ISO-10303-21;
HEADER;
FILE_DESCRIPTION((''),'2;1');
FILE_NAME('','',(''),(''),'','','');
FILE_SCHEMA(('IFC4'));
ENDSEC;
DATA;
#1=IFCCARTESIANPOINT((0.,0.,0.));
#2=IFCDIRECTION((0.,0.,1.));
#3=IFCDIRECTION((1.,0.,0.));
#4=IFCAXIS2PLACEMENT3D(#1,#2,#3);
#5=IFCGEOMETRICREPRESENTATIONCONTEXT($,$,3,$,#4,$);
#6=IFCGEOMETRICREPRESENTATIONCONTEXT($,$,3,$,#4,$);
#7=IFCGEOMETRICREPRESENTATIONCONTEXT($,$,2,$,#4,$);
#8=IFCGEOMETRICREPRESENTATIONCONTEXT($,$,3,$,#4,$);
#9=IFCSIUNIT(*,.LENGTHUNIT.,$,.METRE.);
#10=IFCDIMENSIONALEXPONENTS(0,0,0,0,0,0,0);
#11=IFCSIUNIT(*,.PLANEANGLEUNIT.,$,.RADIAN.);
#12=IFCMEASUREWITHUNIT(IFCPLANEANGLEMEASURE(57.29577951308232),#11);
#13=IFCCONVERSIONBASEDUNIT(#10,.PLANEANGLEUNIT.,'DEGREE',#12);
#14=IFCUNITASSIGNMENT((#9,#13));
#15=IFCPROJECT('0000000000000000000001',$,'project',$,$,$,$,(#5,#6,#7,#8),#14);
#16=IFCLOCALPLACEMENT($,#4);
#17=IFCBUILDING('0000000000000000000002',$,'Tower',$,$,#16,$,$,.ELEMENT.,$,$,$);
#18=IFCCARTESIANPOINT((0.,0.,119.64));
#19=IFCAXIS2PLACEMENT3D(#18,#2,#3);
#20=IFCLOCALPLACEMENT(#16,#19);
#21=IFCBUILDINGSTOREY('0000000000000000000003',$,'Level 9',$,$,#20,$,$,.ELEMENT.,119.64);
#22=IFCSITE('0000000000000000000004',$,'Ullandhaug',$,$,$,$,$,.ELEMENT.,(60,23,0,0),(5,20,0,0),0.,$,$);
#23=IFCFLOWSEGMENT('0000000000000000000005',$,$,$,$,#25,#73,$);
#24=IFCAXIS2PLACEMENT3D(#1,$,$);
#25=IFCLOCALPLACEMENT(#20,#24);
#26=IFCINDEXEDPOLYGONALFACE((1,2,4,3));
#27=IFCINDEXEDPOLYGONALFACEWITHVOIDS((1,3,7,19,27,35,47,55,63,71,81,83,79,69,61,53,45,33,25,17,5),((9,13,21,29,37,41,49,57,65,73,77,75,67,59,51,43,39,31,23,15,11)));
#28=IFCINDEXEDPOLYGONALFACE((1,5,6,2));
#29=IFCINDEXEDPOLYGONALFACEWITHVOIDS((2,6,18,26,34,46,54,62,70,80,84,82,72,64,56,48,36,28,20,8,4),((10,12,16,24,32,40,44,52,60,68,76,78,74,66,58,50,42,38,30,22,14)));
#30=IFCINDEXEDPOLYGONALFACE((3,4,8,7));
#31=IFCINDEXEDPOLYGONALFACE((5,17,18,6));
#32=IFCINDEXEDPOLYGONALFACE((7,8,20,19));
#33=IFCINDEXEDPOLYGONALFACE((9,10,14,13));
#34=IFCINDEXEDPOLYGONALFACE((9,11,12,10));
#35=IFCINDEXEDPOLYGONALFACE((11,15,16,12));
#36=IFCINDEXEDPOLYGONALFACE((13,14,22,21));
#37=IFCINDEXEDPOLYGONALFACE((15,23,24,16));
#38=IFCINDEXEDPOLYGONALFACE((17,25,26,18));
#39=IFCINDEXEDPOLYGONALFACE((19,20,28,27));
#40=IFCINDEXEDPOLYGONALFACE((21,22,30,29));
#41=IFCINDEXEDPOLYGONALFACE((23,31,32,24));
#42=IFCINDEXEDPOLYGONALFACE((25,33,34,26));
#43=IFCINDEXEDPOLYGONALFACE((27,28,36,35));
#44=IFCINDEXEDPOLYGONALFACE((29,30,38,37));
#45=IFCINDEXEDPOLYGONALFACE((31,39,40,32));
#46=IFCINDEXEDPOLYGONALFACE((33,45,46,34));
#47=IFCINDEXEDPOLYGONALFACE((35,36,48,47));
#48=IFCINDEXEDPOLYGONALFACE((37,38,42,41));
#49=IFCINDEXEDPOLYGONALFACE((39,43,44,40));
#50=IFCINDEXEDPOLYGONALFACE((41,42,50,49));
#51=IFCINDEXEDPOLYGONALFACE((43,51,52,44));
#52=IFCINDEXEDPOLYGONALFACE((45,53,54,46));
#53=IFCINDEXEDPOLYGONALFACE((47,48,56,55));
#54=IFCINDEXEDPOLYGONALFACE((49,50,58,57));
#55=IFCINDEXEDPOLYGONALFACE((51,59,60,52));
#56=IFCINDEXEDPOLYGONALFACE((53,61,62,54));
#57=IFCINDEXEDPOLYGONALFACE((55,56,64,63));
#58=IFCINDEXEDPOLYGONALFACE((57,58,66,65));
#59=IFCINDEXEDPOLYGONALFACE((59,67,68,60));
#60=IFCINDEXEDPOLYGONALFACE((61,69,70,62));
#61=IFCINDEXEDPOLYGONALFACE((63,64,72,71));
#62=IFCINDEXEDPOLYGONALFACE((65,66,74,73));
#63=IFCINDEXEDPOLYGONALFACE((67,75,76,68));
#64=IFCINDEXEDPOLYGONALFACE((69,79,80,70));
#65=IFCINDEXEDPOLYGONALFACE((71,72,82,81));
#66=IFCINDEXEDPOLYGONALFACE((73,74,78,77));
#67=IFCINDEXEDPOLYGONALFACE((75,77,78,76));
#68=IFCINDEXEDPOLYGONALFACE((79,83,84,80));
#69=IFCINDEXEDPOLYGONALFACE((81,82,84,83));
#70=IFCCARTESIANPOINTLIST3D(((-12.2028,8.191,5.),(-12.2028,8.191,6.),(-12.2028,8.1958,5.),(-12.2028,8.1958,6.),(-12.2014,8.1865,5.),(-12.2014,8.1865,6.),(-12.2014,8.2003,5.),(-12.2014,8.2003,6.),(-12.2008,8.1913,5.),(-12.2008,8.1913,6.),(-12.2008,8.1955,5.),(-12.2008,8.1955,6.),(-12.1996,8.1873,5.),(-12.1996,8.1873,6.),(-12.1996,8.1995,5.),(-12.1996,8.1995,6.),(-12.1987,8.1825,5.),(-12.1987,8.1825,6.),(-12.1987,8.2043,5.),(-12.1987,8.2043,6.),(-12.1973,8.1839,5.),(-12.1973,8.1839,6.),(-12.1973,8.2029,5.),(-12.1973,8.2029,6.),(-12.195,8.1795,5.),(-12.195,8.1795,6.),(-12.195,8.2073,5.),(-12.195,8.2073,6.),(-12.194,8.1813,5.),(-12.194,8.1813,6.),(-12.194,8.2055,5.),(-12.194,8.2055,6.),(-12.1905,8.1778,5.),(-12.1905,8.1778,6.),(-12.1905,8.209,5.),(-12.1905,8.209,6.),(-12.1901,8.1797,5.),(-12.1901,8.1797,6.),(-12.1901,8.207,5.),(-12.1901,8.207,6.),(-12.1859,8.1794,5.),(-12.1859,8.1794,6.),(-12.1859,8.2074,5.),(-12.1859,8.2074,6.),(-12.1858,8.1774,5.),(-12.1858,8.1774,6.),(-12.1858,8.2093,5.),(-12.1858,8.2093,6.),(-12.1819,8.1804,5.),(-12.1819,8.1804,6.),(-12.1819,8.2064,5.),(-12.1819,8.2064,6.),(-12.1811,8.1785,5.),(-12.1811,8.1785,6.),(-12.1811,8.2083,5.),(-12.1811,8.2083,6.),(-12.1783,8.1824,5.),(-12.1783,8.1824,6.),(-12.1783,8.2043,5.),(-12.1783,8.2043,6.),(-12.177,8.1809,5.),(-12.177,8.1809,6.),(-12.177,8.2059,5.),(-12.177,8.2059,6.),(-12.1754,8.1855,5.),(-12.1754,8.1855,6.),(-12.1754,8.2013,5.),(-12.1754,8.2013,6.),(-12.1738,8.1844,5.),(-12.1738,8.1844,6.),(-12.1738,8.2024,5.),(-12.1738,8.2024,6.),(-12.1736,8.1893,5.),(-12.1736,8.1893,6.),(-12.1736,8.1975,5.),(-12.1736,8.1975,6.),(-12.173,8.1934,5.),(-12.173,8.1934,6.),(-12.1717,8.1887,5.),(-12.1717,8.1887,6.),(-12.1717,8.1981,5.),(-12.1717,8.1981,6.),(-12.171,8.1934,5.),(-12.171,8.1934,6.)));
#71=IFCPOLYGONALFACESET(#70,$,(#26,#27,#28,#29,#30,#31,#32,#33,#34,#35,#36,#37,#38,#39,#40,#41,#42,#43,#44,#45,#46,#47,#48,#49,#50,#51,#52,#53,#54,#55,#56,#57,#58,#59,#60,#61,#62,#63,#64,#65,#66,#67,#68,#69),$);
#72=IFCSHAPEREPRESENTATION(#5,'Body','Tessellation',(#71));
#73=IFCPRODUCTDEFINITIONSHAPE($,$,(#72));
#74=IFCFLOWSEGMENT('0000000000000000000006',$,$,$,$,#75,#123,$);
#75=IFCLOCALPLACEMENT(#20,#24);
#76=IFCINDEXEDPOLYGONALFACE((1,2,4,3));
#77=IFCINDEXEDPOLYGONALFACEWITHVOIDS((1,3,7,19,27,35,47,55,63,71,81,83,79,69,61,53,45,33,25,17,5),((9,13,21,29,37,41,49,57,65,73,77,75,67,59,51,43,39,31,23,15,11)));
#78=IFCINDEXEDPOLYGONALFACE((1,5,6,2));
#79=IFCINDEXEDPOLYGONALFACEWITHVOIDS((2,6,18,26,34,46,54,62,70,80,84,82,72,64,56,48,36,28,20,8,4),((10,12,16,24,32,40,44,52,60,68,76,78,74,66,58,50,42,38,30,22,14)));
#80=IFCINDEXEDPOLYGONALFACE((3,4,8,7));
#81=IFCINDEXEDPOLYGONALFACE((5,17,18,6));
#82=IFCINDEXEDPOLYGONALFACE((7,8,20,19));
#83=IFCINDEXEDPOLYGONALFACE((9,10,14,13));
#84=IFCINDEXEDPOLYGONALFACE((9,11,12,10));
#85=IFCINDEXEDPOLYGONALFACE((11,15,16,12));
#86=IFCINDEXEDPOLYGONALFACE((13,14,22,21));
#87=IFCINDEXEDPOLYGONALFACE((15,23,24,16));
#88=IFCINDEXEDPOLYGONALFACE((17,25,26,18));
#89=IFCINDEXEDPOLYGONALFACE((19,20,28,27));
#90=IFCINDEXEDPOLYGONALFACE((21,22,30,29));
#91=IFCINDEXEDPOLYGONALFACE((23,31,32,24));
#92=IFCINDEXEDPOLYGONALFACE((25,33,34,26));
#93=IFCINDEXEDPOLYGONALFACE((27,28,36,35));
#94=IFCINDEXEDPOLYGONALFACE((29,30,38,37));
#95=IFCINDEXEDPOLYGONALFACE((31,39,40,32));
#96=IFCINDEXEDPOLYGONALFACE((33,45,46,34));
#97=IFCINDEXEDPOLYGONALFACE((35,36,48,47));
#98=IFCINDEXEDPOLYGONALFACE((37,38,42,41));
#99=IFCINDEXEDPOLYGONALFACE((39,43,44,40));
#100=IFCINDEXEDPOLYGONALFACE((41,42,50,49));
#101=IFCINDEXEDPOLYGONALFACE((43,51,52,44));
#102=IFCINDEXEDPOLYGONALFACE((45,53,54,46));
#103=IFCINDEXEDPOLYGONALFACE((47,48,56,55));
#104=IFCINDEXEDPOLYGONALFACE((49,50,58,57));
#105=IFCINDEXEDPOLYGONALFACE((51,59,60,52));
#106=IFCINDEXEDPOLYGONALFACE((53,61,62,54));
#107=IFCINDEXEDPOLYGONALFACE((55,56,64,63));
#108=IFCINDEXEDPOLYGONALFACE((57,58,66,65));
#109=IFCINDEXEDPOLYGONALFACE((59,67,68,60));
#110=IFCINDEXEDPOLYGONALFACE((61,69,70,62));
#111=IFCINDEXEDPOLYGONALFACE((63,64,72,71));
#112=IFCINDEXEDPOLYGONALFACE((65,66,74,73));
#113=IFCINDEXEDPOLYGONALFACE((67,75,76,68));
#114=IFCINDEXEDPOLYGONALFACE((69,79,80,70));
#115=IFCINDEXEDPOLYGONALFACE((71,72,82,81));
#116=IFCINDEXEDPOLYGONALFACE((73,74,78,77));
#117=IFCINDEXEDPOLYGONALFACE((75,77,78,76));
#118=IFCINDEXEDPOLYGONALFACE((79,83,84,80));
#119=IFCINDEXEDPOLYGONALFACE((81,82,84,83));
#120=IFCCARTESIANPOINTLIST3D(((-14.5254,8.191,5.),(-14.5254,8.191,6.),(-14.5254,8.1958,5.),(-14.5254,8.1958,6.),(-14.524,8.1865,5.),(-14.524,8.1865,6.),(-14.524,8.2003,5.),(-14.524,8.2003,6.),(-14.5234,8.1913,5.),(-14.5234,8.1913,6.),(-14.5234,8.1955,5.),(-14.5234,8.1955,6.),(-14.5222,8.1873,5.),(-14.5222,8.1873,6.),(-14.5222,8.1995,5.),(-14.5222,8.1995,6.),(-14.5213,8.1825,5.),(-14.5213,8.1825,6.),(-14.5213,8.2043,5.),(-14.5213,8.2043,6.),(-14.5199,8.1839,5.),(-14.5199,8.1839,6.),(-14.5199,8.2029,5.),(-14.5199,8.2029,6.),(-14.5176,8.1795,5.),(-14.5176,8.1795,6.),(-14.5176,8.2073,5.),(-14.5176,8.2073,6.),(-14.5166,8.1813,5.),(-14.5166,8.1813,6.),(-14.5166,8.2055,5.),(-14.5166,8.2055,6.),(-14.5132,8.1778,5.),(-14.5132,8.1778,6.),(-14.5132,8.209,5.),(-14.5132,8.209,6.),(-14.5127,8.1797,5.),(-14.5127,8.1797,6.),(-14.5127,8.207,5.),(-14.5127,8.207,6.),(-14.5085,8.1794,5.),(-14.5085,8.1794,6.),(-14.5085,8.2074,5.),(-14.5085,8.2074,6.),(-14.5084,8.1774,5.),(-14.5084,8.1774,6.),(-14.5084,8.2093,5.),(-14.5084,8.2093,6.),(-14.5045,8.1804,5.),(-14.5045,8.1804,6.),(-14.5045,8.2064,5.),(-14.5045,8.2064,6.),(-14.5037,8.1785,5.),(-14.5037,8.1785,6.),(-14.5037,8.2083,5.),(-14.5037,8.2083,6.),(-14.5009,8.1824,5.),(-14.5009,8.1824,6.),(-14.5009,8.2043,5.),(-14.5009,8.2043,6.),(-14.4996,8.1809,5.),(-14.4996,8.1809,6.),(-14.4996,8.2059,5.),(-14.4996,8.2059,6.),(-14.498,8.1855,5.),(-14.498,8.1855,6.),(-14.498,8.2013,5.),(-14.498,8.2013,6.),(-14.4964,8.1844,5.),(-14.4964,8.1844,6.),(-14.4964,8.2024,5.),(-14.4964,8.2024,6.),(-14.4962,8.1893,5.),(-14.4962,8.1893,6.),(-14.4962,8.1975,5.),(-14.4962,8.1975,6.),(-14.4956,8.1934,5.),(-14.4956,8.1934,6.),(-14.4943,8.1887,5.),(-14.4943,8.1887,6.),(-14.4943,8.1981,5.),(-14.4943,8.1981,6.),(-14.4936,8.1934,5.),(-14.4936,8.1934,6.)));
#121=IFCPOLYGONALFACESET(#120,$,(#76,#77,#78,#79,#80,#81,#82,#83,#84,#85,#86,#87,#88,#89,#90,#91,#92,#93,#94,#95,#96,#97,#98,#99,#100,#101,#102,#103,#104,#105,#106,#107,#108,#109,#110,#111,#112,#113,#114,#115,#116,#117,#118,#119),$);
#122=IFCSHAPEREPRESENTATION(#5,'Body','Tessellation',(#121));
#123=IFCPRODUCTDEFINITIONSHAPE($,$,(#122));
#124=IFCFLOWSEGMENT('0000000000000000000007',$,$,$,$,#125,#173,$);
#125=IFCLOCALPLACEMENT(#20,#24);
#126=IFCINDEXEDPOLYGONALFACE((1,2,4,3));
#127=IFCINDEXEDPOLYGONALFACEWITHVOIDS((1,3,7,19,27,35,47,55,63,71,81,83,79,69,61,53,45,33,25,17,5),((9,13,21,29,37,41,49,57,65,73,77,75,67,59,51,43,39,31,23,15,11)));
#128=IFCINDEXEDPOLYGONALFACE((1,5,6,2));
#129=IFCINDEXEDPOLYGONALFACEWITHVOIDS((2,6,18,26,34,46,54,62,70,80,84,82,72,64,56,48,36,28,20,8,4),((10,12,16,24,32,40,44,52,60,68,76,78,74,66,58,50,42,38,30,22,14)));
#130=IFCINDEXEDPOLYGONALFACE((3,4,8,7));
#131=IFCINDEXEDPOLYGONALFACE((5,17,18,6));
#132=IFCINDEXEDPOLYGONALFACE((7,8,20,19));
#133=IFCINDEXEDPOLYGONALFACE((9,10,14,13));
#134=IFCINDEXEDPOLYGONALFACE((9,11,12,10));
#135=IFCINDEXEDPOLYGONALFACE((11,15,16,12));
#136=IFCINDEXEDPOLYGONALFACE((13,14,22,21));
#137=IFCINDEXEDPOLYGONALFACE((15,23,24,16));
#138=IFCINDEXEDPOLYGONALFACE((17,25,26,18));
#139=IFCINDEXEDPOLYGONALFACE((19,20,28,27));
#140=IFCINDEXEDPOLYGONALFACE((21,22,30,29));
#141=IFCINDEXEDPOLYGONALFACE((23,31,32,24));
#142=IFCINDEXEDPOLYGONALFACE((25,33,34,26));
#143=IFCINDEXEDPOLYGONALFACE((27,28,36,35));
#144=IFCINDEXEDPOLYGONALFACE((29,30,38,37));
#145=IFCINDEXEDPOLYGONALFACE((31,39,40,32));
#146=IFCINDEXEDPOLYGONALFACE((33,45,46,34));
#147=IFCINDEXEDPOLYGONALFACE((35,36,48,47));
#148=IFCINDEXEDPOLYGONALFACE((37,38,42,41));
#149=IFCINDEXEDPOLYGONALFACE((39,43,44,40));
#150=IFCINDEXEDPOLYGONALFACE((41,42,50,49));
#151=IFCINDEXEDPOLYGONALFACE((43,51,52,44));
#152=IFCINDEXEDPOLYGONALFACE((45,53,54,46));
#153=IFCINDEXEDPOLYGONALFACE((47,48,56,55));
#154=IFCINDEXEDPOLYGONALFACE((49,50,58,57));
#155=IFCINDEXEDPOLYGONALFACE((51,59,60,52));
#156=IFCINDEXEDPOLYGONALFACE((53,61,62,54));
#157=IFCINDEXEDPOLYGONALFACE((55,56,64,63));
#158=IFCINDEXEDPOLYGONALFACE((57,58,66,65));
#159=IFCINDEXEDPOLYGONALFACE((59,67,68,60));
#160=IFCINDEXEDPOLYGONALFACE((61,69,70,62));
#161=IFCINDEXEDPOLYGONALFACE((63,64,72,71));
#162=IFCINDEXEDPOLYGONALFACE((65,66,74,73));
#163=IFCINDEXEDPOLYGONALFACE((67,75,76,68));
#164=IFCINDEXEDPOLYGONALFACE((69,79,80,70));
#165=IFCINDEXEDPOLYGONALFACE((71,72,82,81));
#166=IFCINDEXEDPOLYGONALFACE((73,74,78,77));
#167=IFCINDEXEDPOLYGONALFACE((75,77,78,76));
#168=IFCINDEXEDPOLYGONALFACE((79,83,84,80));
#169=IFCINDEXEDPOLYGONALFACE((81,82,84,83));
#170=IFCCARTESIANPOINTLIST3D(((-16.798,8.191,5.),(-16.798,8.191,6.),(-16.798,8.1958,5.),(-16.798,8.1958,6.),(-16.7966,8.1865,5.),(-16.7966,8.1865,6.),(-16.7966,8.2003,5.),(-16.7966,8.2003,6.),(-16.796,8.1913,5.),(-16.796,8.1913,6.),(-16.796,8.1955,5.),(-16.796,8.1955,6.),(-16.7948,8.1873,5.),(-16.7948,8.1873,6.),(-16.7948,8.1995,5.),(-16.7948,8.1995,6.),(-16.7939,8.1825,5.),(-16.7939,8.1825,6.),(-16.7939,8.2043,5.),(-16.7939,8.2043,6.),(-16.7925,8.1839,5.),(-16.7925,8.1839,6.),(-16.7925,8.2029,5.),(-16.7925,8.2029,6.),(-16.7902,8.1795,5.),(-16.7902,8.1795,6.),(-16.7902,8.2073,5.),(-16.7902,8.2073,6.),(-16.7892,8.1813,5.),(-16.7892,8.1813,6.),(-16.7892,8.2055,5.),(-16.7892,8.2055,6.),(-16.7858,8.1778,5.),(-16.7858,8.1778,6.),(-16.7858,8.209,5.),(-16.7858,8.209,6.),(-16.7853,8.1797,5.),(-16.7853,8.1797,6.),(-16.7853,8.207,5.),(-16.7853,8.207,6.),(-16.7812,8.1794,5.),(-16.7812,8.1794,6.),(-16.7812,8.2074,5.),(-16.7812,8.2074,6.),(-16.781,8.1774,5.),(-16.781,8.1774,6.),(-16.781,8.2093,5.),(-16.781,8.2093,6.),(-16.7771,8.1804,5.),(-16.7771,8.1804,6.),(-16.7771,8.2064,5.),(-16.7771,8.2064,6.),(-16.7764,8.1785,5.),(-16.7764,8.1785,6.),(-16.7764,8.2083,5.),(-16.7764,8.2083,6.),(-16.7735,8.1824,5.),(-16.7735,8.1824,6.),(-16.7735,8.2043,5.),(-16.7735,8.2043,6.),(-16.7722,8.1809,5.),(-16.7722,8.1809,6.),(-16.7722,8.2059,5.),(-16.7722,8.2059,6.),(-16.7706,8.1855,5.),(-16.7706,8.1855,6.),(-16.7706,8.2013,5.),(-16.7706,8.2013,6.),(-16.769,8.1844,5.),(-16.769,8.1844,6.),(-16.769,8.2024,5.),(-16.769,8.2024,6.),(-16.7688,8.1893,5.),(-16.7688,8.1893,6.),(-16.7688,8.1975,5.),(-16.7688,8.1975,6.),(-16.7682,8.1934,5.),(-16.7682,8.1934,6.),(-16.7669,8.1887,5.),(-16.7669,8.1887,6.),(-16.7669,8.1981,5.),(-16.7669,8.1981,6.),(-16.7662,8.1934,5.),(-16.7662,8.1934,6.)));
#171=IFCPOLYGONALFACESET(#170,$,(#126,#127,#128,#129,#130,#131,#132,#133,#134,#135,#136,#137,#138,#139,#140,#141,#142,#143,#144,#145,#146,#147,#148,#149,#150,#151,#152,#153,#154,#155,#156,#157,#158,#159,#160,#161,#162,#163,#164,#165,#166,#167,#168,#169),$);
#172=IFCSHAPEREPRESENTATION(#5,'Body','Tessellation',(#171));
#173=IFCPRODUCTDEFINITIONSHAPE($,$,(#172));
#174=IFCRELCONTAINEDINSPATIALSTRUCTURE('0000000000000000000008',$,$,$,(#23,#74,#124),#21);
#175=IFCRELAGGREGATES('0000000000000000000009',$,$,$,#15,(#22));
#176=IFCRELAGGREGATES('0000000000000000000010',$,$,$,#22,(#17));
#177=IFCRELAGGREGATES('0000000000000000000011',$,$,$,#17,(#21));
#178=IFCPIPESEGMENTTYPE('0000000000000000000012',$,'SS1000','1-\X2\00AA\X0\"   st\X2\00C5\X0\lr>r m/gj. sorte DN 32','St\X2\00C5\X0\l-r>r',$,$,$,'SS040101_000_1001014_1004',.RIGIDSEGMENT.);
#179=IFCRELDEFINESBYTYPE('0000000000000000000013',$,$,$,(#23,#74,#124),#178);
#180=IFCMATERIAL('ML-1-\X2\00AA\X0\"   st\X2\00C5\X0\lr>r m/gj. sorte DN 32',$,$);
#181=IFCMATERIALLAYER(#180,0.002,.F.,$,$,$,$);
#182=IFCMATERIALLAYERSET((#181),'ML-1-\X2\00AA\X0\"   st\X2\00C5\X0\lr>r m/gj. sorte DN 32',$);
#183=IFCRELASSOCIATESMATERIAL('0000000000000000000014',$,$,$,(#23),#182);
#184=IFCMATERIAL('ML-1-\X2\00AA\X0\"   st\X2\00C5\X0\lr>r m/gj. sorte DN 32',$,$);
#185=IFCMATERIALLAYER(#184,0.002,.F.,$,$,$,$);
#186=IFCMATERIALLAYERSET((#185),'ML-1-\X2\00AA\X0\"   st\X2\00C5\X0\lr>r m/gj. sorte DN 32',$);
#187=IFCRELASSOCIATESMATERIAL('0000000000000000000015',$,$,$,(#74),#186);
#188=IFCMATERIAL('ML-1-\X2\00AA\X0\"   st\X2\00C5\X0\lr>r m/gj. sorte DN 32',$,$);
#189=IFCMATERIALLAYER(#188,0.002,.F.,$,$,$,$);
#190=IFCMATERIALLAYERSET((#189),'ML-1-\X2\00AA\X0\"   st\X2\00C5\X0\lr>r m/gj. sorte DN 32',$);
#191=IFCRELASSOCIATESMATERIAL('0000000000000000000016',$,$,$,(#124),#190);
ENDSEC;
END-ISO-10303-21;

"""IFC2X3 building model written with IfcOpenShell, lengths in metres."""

from ifc_helpers import new_model, entity, si_unit, converted_unit, frame, origin_with_axes, origin_2d_with_axis, place, context, project, spatial, hollow_circle, extrude, material, layer, layer_set, layer_usage, type_object, element, save


model = new_model("IFC2X3")

# Units and contexts
context_of_model_1 = context(None, 3, world=origin_with_axes())
context_of_model_2 = context(None, 3, world=origin_with_axes())
context_of_model_3 = context(None, 2, world=origin_with_axes())
context_of_model_4 = context(None, 3, world=origin_with_axes())
ifc_project = project(units=[si_unit("LENGTHUNIT", "METRE"), converted_unit("PLANEANGLEUNIT", "DEGREE", entity("IfcPlaneAngleMeasure", 57.29577951308232), si_unit("PLANEANGLEUNIT", "RADIAN"), dimensions=[0, 0, 0, 0, 0, 0, 0])], contexts=[context_of_model_1, context_of_model_2, context_of_model_3, context_of_model_4])

# Site, building, storey
site = spatial("IfcSite", under=ifc_project, Name="Ullandhaug", CompositionType="ELEMENT", RefLatitude=(60, 23, 0, 0), RefLongitude=(5, 20, 0, 0), RefElevation=0.0)
building_placement = place(None, origin_with_axes())
building = spatial("IfcBuilding", under=site, at=building_placement, Name="Tower", CompositionType="ELEMENT")
storey_placement = place(building_placement, frame((0.0, 0.0, 119.64), z_axis=(0.0, 0.0, 1.0), x_axis=(1.0, 0.0, 0.0)))
storey = spatial("IfcBuildingStorey", under=building, at=storey_placement, Name="Level 9", CompositionType="ELEMENT", Elevation=119.64)

# Flow segments
ifc_material_1 = material(Name="ML-1-ª\"   stÅlr>r m/gj. sorte DN 32")
ifc_layer_1 = layer(ifc_material_1, 0.002, ventilated=False)
ifc_layer_set_1 = layer_set([ifc_layer_1], Name="ML-1-ª\"   stÅlr>r m/gj. sorte DN 32")
ifc_layer_usage_1 = layer_usage(ifc_layer_set_1, "AXIS2", "POSITIVE", 0.0)
pipe_segment_type_1 = type_object("IfcPipeSegmentType", Name="SS1000", Description="1-ª\"   stÅlr>r m/gj. sorte DN 32", ApplicableOccurrence="StÅl-r>r", ElementType="SS040101_000_1001014_1004", PredefinedType="RIGIDSEGMENT")
flow_segment_1_placement = place(storey_placement, frame((-12.187, 8.1934, 5.0), z_axis=(0.0, 0.0, 1.0), x_axis=(1.0, 0.0, 0.0)))
element("IfcFlowSegment", 1, at=flow_segment_1_placement, inside=storey, type_object=pipe_segment_type_1, material=ifc_layer_usage_1, context=context_of_model_1, shape_type="SweptSolid", body=[
    extrude(hollow_circle(Radius=0.016, WallThickness=0.002, at=origin_2d_with_axis()), origin_with_axes(), (0.0, 0.0, 1.0), 1.0),
])
ifc_material_2 = material(Name="ML-1-ª\"   stÅlr>r m/gj. sorte DN 32")
ifc_layer_2 = layer(ifc_material_2, 0.002, ventilated=False)
ifc_layer_set_2 = layer_set([ifc_layer_2], Name="ML-1-ª\"   stÅlr>r m/gj. sorte DN 32")
ifc_layer_usage_2 = layer_usage(ifc_layer_set_2, "AXIS2", "POSITIVE", 0.0)
flow_segment_2_placement = place(storey_placement, frame((-14.5096, 8.1934, 5.0), z_axis=(0.0, 0.0, 1.0), x_axis=(1.0, 0.0, 0.0)))
element("IfcFlowSegment", 2, at=flow_segment_2_placement, inside=storey, type_object=pipe_segment_type_1, material=ifc_layer_usage_2, context=context_of_model_1, shape_type="SweptSolid", body=[
    extrude(hollow_circle(Radius=0.016, WallThickness=0.002, at=origin_2d_with_axis()), origin_with_axes(), (0.0, 0.0, 1.0), 1.0),
])
ifc_material_3 = material(Name="ML-1-ª\"   stÅlr>r m/gj. sorte DN 32")
ifc_layer_3 = layer(ifc_material_3, 0.002, ventilated=False)
ifc_layer_set_3 = layer_set([ifc_layer_3], Name="ML-1-ª\"   stÅlr>r m/gj. sorte DN 32")
ifc_layer_usage_3 = layer_usage(ifc_layer_set_3, "AXIS2", "POSITIVE", 0.0)
flow_segment_3_placement = place(storey_placement, frame((-16.7822, 8.1934, 5.0), z_axis=(0.0, 0.0, 1.0), x_axis=(1.0, 0.0, 0.0)))
element("IfcFlowSegment", 3, at=flow_segment_3_placement, inside=storey, type_object=pipe_segment_type_1, material=ifc_layer_usage_3, context=context_of_model_1, shape_type="SweptSolid", body=[
    extrude(hollow_circle(Radius=0.016, WallThickness=0.002, at=origin_2d_with_axis()), origin_with_axes(), (0.0, 0.0, 1.0), 1.0),
])

save(model, "model.ifc")
